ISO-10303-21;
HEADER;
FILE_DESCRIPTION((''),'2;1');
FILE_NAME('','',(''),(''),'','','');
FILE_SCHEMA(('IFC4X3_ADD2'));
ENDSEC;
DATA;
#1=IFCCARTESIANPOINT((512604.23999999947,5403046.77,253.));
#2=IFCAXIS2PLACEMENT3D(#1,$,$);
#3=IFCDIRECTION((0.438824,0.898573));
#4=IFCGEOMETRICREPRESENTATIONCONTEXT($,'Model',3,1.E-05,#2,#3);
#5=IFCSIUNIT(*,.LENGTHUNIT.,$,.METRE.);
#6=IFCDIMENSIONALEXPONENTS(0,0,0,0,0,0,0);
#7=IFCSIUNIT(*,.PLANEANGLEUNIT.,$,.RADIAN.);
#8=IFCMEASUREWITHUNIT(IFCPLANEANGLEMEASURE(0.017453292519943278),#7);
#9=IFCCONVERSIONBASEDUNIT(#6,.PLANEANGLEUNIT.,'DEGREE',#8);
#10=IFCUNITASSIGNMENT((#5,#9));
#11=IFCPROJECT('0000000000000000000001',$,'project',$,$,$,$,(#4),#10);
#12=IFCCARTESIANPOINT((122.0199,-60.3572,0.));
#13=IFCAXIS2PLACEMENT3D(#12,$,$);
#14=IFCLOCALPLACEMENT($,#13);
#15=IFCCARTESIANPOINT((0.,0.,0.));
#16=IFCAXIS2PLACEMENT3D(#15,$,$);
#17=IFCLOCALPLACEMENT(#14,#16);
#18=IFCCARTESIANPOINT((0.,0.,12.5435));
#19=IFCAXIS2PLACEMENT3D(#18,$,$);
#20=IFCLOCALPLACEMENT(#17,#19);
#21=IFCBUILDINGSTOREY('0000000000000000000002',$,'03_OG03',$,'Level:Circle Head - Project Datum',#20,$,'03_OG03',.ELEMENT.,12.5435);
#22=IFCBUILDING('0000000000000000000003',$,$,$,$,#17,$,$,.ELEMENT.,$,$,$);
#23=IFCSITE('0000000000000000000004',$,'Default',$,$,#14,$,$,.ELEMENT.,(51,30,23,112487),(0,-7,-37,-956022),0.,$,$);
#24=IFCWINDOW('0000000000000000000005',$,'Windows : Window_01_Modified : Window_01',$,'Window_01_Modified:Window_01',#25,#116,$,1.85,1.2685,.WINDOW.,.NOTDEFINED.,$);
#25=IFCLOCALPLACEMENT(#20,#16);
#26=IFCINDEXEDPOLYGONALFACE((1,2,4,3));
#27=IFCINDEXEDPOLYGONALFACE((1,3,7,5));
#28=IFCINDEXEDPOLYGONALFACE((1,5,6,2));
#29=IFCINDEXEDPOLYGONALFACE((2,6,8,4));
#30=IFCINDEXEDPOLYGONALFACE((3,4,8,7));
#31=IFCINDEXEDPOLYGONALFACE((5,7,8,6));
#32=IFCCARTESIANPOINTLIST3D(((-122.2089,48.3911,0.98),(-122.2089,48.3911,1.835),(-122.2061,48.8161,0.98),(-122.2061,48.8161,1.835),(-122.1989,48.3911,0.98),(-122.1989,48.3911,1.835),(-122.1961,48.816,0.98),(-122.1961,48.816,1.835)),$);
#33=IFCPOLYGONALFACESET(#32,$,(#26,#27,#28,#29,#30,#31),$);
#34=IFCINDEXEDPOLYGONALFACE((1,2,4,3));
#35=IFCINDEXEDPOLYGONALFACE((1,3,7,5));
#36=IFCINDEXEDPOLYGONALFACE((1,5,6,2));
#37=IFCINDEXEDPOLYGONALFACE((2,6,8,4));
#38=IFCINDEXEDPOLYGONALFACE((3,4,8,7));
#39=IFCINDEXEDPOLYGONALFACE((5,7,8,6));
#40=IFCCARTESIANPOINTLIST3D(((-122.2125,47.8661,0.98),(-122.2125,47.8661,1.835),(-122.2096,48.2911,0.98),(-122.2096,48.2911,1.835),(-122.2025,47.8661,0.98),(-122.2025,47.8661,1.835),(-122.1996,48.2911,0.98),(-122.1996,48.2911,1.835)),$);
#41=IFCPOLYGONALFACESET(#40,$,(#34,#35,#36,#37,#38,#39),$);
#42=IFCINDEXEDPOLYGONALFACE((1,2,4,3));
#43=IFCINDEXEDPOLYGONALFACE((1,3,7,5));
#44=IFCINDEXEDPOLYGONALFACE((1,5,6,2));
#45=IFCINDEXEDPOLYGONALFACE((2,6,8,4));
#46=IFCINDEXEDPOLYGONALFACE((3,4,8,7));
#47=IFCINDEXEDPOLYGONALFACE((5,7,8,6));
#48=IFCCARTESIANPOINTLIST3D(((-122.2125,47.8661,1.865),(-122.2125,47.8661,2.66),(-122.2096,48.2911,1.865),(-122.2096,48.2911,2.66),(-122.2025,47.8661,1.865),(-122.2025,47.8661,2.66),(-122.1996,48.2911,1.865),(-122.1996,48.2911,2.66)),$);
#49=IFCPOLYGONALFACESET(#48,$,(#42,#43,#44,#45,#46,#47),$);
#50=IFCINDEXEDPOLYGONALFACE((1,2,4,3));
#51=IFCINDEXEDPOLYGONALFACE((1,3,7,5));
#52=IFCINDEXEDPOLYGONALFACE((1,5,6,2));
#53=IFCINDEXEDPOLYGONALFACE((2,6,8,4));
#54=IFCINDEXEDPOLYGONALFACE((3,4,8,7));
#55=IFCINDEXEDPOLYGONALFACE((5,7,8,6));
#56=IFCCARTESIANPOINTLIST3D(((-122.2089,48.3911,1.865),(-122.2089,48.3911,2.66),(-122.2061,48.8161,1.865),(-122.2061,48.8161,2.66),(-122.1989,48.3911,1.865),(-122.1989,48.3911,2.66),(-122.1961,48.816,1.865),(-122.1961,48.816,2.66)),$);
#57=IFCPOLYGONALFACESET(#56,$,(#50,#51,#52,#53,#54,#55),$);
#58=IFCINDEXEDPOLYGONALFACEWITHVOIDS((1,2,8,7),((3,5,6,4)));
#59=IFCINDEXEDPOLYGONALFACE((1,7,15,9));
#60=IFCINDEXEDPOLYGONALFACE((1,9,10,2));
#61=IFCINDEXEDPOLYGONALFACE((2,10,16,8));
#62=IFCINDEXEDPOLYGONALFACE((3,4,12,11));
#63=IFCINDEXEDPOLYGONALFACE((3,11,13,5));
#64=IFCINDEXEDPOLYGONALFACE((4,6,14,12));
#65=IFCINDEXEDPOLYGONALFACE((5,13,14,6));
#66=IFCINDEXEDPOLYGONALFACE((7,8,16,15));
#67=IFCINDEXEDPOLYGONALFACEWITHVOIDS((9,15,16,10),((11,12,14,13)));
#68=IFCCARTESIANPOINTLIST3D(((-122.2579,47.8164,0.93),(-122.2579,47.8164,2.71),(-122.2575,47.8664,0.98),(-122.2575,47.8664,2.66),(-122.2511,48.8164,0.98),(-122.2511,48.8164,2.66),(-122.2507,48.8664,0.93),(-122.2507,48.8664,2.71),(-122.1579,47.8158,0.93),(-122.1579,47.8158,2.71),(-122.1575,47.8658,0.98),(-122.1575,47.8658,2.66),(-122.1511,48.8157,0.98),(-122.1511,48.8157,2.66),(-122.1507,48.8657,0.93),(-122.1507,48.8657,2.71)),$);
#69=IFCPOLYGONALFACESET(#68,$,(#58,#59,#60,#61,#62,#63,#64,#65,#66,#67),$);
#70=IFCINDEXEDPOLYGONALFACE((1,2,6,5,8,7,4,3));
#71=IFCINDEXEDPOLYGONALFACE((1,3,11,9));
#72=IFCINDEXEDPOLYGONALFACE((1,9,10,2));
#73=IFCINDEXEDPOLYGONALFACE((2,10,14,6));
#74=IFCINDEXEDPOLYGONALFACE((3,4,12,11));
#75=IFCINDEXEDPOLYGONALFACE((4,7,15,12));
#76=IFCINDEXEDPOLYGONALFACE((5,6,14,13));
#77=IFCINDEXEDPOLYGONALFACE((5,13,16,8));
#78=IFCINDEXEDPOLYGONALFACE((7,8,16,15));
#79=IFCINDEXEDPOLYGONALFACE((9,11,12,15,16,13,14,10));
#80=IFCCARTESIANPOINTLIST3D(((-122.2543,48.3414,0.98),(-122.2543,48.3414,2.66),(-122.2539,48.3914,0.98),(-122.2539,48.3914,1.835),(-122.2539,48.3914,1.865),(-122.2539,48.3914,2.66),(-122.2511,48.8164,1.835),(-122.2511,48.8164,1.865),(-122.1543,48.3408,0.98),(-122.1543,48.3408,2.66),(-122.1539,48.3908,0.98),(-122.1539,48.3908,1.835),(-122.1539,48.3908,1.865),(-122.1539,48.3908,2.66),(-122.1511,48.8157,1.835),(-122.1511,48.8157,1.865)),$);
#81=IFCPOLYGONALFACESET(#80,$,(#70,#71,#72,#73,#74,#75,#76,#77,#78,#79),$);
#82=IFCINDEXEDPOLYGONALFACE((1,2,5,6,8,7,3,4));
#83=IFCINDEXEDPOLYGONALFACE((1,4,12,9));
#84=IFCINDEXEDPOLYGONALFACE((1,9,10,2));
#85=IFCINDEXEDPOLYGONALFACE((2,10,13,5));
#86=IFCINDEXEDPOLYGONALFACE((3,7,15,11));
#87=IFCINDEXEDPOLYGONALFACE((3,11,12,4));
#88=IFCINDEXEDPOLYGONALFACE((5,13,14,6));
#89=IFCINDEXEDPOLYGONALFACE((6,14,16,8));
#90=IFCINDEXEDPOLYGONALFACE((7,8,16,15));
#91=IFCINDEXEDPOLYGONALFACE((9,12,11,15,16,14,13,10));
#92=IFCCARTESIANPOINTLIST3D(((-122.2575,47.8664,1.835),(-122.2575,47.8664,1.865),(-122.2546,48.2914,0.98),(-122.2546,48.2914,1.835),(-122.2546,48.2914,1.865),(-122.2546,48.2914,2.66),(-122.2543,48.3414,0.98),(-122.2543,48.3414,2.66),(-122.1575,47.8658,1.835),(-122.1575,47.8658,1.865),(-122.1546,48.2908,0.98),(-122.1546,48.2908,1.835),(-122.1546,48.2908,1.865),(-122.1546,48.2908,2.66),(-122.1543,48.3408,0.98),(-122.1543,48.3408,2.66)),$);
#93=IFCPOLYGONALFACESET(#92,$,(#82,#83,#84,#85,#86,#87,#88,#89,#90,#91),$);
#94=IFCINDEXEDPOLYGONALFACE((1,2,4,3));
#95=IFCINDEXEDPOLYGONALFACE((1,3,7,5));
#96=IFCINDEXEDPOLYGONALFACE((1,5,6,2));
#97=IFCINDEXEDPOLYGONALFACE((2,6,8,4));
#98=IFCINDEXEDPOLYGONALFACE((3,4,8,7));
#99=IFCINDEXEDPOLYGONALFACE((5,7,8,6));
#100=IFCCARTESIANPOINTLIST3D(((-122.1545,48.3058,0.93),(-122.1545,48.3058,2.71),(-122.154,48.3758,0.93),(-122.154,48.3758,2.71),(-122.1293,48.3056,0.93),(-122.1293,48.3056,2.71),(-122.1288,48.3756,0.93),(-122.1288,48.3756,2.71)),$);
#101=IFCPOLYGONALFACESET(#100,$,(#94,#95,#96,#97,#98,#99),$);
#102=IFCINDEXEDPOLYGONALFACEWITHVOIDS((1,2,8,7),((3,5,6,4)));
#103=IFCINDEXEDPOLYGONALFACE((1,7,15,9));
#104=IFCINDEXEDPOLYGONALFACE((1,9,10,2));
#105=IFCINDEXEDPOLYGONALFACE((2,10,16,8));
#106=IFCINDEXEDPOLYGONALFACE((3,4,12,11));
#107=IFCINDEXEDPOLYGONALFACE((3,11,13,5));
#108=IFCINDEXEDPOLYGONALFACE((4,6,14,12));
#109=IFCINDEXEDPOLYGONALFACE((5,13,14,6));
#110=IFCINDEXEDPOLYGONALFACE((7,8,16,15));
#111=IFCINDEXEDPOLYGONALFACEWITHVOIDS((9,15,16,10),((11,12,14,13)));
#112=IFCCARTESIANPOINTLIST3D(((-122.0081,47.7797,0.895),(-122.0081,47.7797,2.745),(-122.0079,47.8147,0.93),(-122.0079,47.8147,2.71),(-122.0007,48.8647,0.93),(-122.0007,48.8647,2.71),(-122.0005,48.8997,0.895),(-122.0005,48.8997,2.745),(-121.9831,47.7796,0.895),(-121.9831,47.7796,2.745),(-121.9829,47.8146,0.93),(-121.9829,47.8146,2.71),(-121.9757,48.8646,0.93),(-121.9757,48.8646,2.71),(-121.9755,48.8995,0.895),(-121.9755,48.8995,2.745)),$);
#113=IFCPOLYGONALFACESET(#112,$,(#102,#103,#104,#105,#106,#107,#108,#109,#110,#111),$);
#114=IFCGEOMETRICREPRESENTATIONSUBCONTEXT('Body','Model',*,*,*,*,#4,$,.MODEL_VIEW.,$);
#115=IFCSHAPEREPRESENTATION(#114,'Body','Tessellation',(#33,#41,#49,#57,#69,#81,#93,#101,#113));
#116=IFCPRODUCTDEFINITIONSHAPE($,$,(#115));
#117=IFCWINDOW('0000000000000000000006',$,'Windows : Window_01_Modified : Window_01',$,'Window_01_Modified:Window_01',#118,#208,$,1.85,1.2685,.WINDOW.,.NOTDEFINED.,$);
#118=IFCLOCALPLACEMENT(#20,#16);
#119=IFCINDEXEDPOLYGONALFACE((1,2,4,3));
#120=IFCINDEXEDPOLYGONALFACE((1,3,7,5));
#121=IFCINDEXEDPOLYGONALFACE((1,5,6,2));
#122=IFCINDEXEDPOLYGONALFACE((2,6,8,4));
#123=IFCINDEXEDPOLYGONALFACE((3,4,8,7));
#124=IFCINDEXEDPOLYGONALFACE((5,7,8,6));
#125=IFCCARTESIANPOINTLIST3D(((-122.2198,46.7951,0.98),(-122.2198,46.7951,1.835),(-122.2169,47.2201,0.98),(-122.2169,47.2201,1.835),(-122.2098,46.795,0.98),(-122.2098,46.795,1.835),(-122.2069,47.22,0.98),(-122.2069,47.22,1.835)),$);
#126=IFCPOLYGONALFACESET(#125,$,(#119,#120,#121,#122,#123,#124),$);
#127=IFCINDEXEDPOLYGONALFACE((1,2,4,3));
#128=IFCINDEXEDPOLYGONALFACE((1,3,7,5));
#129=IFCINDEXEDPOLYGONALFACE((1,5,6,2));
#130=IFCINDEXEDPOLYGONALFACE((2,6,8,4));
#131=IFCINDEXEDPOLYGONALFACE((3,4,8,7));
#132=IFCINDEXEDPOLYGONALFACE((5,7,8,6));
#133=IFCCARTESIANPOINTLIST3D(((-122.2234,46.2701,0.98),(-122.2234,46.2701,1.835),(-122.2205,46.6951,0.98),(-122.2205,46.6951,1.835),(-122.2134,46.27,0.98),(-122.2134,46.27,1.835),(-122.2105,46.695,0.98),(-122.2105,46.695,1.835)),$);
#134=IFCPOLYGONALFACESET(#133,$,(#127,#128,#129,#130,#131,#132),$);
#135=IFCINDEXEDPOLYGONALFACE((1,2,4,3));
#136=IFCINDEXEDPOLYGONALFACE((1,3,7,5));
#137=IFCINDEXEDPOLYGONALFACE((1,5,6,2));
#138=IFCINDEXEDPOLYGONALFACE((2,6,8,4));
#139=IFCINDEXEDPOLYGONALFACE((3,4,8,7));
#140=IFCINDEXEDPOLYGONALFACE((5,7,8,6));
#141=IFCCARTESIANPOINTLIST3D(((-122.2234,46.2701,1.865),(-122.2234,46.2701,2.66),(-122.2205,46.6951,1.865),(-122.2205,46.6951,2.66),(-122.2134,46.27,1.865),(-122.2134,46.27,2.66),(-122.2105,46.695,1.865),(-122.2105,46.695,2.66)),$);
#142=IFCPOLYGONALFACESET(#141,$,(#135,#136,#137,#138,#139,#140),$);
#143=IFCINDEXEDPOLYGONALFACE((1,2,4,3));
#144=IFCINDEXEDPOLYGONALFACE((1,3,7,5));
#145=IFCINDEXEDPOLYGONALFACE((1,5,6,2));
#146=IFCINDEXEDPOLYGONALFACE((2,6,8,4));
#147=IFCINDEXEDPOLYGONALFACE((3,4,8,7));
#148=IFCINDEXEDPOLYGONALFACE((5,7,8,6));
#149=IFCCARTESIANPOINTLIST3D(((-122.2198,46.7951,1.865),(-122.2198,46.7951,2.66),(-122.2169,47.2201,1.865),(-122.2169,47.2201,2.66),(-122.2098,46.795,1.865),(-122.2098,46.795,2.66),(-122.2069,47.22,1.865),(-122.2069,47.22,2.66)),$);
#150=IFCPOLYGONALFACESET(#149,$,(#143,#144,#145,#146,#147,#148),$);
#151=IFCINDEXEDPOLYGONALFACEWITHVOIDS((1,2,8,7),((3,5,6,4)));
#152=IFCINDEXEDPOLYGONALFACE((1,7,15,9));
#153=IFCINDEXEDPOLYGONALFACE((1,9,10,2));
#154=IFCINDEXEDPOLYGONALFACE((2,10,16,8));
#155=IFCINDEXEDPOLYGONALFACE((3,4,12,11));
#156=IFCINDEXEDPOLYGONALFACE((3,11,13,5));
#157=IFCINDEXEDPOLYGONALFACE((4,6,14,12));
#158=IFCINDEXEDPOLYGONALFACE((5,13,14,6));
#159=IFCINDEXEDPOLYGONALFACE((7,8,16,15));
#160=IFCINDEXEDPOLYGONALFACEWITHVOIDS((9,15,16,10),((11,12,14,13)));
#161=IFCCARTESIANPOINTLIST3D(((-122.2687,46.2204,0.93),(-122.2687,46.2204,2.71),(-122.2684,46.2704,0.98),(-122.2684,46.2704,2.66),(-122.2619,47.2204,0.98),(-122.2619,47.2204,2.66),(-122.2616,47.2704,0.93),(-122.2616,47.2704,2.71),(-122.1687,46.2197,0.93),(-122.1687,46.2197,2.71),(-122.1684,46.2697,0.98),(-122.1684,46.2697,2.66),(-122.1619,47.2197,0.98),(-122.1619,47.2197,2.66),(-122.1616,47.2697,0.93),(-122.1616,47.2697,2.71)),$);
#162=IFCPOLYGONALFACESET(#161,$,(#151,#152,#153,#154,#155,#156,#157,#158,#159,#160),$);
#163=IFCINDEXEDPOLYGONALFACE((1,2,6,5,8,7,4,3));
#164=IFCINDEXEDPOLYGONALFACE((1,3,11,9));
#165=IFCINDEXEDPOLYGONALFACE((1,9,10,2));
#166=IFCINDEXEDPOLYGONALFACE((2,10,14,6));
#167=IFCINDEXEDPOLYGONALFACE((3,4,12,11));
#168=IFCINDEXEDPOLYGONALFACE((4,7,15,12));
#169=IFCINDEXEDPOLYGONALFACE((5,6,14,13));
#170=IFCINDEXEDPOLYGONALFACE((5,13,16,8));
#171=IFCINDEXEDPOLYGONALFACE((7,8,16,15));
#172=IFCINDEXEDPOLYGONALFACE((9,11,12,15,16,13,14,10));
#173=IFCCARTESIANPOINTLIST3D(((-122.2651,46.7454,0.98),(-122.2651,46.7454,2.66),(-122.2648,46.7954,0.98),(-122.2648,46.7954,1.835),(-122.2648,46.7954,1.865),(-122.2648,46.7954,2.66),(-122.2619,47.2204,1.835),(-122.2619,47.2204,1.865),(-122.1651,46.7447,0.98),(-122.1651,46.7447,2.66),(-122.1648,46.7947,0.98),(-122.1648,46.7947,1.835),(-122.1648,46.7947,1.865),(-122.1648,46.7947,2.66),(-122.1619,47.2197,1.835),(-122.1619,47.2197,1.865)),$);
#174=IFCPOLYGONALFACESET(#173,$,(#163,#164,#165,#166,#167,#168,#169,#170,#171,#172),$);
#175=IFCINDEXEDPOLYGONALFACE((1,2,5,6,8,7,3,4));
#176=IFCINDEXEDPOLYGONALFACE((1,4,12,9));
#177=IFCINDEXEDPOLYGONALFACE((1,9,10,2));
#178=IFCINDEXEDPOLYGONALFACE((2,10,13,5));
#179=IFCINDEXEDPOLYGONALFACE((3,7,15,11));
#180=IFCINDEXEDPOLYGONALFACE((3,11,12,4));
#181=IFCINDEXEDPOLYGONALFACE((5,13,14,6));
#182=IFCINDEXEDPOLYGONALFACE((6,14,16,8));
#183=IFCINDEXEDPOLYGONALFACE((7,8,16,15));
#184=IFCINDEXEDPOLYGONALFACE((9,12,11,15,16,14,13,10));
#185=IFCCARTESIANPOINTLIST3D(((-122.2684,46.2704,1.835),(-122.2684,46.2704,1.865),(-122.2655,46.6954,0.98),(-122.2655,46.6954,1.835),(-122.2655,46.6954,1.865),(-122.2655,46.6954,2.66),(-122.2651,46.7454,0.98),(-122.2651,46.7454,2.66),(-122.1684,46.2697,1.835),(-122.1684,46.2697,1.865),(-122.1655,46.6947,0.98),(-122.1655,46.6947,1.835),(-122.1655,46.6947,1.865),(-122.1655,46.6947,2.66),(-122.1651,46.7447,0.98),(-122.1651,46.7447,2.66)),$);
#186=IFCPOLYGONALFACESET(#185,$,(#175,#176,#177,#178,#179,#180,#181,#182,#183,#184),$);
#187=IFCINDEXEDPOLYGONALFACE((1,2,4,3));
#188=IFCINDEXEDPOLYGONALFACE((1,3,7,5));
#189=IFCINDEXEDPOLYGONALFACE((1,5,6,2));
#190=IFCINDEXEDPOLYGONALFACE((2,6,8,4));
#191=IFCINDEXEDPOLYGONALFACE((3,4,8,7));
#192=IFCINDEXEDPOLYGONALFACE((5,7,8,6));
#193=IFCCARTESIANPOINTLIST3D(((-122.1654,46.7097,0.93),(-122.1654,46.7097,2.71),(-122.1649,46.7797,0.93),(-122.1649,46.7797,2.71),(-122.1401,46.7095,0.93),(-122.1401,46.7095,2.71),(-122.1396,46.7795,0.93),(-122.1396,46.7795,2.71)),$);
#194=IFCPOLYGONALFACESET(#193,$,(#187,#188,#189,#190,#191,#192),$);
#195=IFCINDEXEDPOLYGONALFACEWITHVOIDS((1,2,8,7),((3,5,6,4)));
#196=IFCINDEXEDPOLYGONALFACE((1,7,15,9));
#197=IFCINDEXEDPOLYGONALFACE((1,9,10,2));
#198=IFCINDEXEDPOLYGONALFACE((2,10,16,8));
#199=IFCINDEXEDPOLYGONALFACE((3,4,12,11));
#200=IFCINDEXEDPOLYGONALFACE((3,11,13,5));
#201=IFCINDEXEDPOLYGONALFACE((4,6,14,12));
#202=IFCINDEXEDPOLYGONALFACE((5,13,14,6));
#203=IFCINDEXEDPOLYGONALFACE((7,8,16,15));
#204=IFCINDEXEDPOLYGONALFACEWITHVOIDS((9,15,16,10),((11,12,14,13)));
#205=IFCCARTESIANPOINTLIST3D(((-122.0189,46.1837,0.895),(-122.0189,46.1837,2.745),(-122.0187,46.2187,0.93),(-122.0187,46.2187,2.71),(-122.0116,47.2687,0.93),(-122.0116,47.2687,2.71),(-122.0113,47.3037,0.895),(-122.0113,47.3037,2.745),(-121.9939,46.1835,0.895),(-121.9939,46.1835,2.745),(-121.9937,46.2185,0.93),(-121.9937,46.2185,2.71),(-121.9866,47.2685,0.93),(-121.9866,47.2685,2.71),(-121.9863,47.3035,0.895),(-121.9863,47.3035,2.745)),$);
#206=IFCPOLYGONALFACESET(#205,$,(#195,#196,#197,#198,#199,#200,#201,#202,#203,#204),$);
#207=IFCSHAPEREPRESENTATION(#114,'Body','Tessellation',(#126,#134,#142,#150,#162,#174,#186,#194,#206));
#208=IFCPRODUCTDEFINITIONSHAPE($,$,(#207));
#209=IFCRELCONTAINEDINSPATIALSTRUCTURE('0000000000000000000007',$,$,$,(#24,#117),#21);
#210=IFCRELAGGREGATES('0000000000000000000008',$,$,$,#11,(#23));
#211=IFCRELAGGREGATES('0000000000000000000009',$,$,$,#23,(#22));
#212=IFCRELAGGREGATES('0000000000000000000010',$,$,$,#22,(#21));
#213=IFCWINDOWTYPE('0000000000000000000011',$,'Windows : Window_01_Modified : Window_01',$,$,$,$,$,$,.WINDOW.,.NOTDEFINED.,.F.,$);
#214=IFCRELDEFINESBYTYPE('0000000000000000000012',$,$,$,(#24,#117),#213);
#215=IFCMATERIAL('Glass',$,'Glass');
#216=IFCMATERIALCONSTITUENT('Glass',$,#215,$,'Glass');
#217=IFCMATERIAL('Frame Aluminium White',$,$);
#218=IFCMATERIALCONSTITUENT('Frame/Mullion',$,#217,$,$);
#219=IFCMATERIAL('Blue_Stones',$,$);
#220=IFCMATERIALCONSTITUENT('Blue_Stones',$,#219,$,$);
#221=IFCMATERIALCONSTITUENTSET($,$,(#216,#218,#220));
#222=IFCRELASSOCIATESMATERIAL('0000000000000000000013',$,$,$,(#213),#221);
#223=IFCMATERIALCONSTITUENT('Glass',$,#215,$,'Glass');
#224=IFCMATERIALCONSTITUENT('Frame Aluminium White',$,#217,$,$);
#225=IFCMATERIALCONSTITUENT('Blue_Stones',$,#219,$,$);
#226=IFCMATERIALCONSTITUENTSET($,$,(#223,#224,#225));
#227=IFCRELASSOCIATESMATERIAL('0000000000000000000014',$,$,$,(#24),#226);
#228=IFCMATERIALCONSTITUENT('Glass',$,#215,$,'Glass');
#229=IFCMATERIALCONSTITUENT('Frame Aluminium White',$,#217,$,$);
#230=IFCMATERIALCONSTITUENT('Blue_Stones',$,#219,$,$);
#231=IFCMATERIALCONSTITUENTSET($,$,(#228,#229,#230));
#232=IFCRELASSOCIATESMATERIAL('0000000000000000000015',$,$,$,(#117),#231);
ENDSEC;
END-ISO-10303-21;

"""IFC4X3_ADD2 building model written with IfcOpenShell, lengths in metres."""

from ifc_helpers import new_model, entity, si_unit, converted_unit, direction, frame, frame_2d, origin, place, context, subcontext, project, spatial, polyline, rectangle, outline, extrude, source, transform, mapped, material, constituent, constituent_set, type_object, type_shapes, element, save


model = new_model("IFC4X3_ADD2")

# Units and contexts
model_context = context("Model", 3, precision=1e-05, world=frame((512604.23999999947, 5403046.77, 253.0)), true_north=direction((0.438824, 0.898573)))
body_context = subcontext(model_context, "Body", "Model", "MODEL_VIEW")
ifc_project = project(units=[si_unit("LENGTHUNIT", "METRE"), converted_unit("PLANEANGLEUNIT", "DEGREE", entity("IfcPlaneAngleMeasure", 0.017453292519943278), si_unit("PLANEANGLEUNIT", "RADIAN"), dimensions=[0, 0, 0, 0, 0, 0, 0])], contexts=[model_context])

# Site, building, storey
site_placement = place(None, frame((122.0199, -60.3572, 0.0)))
site = spatial("IfcSite", under=ifc_project, at=site_placement, Name="Default", CompositionType="ELEMENT", RefLatitude=(51, 30, 23, 112487), RefLongitude=(0, -7, -37, -956022), RefElevation=0.0)
building_placement = place(site_placement, origin())
building = spatial("IfcBuilding", under=site, at=building_placement, CompositionType="ELEMENT")
storey_placement = place(building_placement, frame((0.0, 0.0, 12.5435)))
storey = spatial("IfcBuildingStorey", under=building, at=storey_placement, Name="03_OG03", ObjectType="Level:Circle Head - Project Datum", LongName="03_OG03", CompositionType="ELEMENT", Elevation=12.5435)

# Windows
ifc_material_1 = material(Name="Glass", Category="Glass")
ifc_material_2 = material(Name="Frame Aluminium White")
ifc_material_3 = material(Name="Blue_Stones")
ifc_constituent_1 = constituent(ifc_material_1, Name="Glass", Category="Glass")
ifc_constituent_2 = constituent(ifc_material_2, Name="Frame Aluminium White")
ifc_constituent_3 = constituent(ifc_material_3, Name="Blue_Stones")
ifc_constituent_set_1 = constituent_set(constituents=[ifc_constituent_1, ifc_constituent_2, ifc_constituent_3])
ifc_constituent_4 = constituent(ifc_material_1, Name="Glass", Category="Glass")
ifc_constituent_5 = constituent(ifc_material_2, Name="Frame/Mullion")
ifc_constituent_6 = constituent(ifc_material_3, Name="Blue_Stones")
ifc_constituent_set_2 = constituent_set(constituents=[ifc_constituent_4, ifc_constituent_5, ifc_constituent_6])
window_type_1 = type_object("IfcWindowType", Name="Windows : Window_01_Modified : Window_01", ParameterTakesPrecedence=False, PartitioningType="NOTDEFINED", PredefinedType="WINDOW", material=ifc_constituent_set_2)
shared_shape_1 = source(origin(), body_context, "Body", "SweptSolid", [
    extrude(rectangle(XDim=0.425, YDim=0.01, at=frame_2d((0.0, 0.0), x_axis=(1.0, 0.0))), frame((0.3437, -0.2, 0.0514), z_axis=(0.0, 0.0, 1.0), x_axis=(-1.0, 0.0, 0.0)), (0.0, 0.0, 1.0), 0.855),
    extrude(rectangle(XDim=0.01, YDim=0.425, at=frame_2d((0.0, 0.0), x_axis=(1.0, 0.0))), frame((0.8687, -0.2, 0.0514), z_axis=(0.0, 0.0, 1.0), x_axis=(0.0, 1.0, 0.0)), (0.0, 0.0, 1.0), 0.855),
    extrude(rectangle(XDim=0.425, YDim=0.01, at=frame_2d((0.0, 0.0), x_axis=(1.0, 0.0))), frame((0.8687, -0.2, 0.9364), z_axis=(0.0, 0.0, 1.0), x_axis=(-1.0, 0.0, 0.0)), (0.0, 0.0, 1.0), 0.795),
    extrude(rectangle(XDim=0.425, YDim=0.01, at=frame_2d((0.0, 0.0), x_axis=(1.0, 0.0))), frame((0.3437, -0.2, 0.9364), z_axis=(0.0, 0.0, 1.0), x_axis=(-1.0, 0.0, 0.0)), (0.0, 0.0, 1.0), 0.795),
    extrude(outline(polyline([(-0.89, -0.525), (0.89, -0.525), (0.89, 0.525), (-0.89, 0.525), (-0.89, -0.525)]), holes=[polyline([(0.84, 0.475), (0.84, -0.475), (-0.84, -0.475), (-0.84, 0.475), (0.84, 0.475)])]), frame((0.6062, -0.25, 0.8914), z_axis=(0.0, 1.0, 0.0), x_axis=(0.0, 0.0, 1.0)), (0.0, 0.0, 1.0), 0.1),
    extrude(outline(polyline([(0.03, 0.0937), (0.825, 0.0937), (0.825, 0.1438), (-0.855, 0.1438), (-0.855, 0.0937), (0.0, 0.0937), (0.0, -0.3312), (0.03, -0.3312), (0.03, 0.0937)])), frame((0.4625, -0.25, 0.9064), z_axis=(0.0, 1.0, 0.0), x_axis=(0.0, 0.0, 1.0)), (0.0, 0.0, 1.0), 0.1),
    extrude(outline(polyline([(-0.825, -0.0938), (-0.825, -0.1437), (0.855, -0.1437), (0.855, -0.0938), (0.0, -0.0938), (0.0, 0.3313), (-0.03, 0.3313), (-0.03, -0.0938), (-0.825, -0.0938)])), frame((0.75, -0.25, 0.9064), z_axis=(0.0, -1.0, 0.0), x_axis=(0.0, 0.0, -1.0)), (0.0, 0.0, -1.0), 0.1),
    extrude(rectangle(XDim=0.0253, YDim=0.07, at=frame_2d((0.0, 0.0), x_axis=(1.0, 0.0))), frame((0.6062, -0.1374, 0.0014), z_axis=(0.0, 0.0, 1.0), x_axis=(0.0, -1.0, 0.0)), (0.0, 0.0, 1.0), 1.78),
    extrude(outline(polyline([(-0.56, -0.925), (0.56, -0.925), (0.56, 0.925), (-0.56, 0.925), (-0.56, -0.925)]), holes=[polyline([(-0.525, -0.89), (-0.525, 0.89), (0.525, 0.89), (0.525, -0.89), (-0.525, -0.89)])]), frame((0.6062, 0.0, 0.8914), z_axis=(0.0, 1.0, 0.0), x_axis=(1.0, 0.0, 0.0)), (0.0, 0.0, 1.0), 0.025),
])
type_shapes(window_type_1, [shared_shape_1])
window_1_placement = place(storey_placement, frame((-122.0002, 48.946, 0.9286), z_axis=(0.0, 0.0, 1.0), x_axis=(-0.0068, -0.999977, 0.0)))
element("IfcWindow", 1, at=window_1_placement, inside=storey, type_object=window_type_1, material=ifc_constituent_set_1, Name="Windows : Window_01_Modified : Window_01", ObjectType="Window_01_Modified:Window_01", OverallHeight=1.85, OverallWidth=1.2685, PartitioningType="NOTDEFINED", PredefinedType="WINDOW", context=body_context, shape_type="MappedRepresentation", body=[
    mapped(shared_shape_1, transform((0.0, 0.0, 0.0), scale=1.0)),
])
ifc_constituent_7 = constituent(ifc_material_1, Name="Glass", Category="Glass")
ifc_constituent_8 = constituent(ifc_material_2, Name="Frame Aluminium White")
ifc_constituent_9 = constituent(ifc_material_3, Name="Blue_Stones")
ifc_constituent_set_3 = constituent_set(constituents=[ifc_constituent_7, ifc_constituent_8, ifc_constituent_9])
window_2_placement = place(storey_placement, frame((-122.011, 47.3499, 0.9286), z_axis=(0.0, 0.0, 1.0), x_axis=(-0.0068, -0.999977, 0.0)))
element("IfcWindow", 2, at=window_2_placement, inside=storey, type_object=window_type_1, material=ifc_constituent_set_3, Name="Windows : Window_01_Modified : Window_01", ObjectType="Window_01_Modified:Window_01", OverallHeight=1.85, OverallWidth=1.2685, PartitioningType="NOTDEFINED", PredefinedType="WINDOW", context=body_context, shape_type="MappedRepresentation", body=[
    mapped(shared_shape_1, transform((0.0, 0.0, 0.0), scale=1.0)),
])

save(model, "model.ifc")
